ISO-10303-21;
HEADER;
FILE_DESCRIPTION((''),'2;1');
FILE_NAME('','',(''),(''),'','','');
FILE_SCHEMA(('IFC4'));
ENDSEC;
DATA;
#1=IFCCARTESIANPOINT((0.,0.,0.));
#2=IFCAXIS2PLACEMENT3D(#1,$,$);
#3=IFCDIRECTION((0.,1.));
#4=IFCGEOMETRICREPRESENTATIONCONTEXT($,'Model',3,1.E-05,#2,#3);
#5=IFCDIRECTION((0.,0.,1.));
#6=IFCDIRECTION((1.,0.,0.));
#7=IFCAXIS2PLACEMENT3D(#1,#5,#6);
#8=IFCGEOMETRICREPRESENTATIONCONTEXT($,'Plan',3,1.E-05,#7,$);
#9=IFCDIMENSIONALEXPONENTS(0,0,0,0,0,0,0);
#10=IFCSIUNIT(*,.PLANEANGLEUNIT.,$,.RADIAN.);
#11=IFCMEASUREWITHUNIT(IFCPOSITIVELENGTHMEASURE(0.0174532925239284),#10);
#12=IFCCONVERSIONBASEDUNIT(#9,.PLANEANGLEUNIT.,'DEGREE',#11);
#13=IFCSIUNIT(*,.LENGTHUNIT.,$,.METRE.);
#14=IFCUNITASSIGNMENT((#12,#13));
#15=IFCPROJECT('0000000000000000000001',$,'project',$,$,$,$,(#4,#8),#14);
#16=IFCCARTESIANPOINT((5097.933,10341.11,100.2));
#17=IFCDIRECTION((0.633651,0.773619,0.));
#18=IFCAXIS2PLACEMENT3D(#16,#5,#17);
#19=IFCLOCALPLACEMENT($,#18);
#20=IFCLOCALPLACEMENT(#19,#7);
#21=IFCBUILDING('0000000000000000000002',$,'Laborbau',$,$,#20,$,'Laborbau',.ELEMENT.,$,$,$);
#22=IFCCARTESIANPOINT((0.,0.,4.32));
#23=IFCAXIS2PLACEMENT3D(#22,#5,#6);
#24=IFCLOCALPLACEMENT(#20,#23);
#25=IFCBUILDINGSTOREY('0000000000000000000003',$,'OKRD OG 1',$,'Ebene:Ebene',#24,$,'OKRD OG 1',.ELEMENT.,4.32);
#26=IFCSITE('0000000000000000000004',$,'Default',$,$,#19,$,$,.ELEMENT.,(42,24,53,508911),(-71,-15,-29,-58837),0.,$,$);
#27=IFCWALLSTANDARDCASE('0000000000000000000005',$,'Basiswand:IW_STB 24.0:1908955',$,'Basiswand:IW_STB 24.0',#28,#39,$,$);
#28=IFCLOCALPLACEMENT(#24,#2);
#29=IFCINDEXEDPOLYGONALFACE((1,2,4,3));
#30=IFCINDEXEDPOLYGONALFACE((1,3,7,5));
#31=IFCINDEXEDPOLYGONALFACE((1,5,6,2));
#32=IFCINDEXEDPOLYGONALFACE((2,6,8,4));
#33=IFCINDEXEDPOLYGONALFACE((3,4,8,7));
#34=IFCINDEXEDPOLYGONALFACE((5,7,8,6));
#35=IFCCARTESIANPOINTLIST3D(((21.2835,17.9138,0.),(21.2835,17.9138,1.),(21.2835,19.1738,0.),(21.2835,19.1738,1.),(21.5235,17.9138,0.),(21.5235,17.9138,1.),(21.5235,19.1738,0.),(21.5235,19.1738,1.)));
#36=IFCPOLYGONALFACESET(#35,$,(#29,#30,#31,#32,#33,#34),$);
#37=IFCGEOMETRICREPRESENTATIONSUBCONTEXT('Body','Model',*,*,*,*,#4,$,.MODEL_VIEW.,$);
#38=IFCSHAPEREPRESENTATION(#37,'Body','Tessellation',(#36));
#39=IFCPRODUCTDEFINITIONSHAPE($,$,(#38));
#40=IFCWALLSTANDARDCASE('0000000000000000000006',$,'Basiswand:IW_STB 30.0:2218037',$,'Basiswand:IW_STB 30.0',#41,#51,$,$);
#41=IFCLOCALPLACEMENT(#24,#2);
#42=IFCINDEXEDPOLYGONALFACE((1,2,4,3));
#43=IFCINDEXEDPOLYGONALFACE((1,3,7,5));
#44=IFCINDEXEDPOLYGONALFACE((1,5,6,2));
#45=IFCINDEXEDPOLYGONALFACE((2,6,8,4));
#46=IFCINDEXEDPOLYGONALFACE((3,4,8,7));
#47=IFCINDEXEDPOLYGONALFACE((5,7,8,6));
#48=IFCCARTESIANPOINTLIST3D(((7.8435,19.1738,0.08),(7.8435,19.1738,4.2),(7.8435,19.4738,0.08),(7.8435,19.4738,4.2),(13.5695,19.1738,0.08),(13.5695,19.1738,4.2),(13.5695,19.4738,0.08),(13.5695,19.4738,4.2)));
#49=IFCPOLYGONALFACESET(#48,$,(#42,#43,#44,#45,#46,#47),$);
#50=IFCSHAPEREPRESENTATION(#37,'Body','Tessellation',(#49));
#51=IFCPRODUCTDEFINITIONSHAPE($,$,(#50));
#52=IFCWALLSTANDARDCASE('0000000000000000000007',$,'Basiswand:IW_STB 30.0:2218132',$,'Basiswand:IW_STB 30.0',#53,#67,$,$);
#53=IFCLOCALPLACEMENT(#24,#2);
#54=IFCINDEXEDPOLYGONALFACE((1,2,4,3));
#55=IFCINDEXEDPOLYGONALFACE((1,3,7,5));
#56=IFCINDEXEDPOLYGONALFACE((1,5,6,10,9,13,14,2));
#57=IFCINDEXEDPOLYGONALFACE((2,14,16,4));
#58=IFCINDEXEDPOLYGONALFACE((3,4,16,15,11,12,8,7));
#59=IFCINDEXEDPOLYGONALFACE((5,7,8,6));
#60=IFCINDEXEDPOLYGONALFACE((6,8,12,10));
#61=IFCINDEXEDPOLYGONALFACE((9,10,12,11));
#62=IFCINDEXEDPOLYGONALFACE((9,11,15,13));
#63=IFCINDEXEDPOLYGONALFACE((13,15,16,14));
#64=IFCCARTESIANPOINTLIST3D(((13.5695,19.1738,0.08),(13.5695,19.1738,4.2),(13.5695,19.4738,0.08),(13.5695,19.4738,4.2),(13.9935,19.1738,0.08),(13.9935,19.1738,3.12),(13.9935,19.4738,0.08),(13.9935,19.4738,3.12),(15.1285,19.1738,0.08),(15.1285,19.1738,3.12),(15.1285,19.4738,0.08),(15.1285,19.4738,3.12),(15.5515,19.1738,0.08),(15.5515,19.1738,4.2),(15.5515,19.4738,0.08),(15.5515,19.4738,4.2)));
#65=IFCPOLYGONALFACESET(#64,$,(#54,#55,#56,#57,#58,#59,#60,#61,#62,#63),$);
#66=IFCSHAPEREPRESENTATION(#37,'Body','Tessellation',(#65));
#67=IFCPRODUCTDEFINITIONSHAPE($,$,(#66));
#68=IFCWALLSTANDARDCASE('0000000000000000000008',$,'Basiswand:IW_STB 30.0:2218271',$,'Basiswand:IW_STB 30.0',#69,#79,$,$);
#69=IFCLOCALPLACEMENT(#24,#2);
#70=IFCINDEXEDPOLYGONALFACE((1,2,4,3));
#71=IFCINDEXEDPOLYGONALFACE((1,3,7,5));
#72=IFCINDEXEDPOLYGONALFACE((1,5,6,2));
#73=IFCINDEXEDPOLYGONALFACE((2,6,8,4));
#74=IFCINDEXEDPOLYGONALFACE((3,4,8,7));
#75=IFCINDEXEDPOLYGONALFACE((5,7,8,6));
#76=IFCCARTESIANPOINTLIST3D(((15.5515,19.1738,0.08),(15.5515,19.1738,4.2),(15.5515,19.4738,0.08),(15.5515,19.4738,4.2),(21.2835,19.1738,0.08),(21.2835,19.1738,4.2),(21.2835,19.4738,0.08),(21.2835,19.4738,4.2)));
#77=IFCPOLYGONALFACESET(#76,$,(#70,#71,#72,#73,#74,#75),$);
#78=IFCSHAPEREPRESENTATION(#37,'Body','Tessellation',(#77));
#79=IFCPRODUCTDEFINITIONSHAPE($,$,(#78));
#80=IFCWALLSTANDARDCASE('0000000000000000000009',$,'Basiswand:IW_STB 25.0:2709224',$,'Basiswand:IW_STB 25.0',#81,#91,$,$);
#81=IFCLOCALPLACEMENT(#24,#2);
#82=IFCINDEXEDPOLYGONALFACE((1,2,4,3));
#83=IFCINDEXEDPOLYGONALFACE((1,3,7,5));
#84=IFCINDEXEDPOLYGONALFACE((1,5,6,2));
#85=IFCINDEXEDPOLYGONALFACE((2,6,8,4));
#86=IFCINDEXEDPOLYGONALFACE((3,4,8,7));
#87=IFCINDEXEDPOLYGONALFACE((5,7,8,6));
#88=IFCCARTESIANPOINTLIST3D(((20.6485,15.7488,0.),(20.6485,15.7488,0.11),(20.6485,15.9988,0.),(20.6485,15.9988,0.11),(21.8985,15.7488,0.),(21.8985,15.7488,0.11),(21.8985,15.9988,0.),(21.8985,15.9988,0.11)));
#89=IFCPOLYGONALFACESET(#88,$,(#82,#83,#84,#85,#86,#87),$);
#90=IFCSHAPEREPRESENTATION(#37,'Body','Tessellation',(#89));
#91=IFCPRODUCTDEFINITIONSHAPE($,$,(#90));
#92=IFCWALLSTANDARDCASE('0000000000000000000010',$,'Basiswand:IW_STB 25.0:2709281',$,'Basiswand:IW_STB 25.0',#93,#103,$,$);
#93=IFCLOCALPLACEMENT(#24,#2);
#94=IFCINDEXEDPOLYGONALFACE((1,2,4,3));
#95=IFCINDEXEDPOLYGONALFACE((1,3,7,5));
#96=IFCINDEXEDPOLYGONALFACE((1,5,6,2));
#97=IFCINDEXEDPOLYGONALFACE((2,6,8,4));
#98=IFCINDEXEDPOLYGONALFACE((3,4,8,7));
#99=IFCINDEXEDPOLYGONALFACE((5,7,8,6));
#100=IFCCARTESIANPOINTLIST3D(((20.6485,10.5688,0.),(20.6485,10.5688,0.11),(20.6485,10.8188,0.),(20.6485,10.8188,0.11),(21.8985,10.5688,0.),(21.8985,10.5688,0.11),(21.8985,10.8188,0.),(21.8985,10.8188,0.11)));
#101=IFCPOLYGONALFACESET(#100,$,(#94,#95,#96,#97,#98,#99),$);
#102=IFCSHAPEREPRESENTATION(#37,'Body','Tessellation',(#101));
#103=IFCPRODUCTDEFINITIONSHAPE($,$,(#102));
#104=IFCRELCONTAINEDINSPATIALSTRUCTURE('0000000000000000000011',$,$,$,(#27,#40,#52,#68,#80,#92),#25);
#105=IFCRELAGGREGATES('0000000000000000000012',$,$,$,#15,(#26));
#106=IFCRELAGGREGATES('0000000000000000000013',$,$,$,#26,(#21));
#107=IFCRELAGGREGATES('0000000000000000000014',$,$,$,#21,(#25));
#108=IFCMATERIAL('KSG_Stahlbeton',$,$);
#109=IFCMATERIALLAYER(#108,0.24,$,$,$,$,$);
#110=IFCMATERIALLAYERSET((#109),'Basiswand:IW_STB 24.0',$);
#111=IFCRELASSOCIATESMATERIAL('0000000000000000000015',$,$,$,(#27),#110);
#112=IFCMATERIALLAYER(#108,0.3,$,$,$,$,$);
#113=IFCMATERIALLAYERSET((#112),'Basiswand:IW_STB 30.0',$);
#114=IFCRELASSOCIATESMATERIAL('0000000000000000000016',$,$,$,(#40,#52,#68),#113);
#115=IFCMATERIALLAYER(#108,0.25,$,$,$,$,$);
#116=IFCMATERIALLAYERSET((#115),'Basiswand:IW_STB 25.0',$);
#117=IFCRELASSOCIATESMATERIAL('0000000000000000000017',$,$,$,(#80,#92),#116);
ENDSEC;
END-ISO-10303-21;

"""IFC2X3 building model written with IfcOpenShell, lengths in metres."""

from ifc_helpers import new_model, entity, si_unit, converted_unit, direction, frame, frame_2d, origin, origin_with_axes, place, context, subcontext, project, spatial, rectangle, extrude, material, layer, layer_set, layer_usage, element, save


model = new_model("IFC2X3")

# Units and contexts
model_context = context("Model", 3, precision=1e-05, world=origin(), true_north=direction((0.0, 1.0)))
plan_context = context("Plan", 3, precision=1e-05, world=origin_with_axes())
body_context = subcontext(model_context, "Body", "Model", "MODEL_VIEW")
ifc_project = project(units=[converted_unit("PLANEANGLEUNIT", "DEGREE", entity("IfcPositiveLengthMeasure", 0.0174532925239284), si_unit("PLANEANGLEUNIT", "RADIAN"), dimensions=[0, 0, 0, 0, 0, 0, 0]), si_unit("LENGTHUNIT", "METRE")], contexts=[model_context, plan_context])

# Site, building, storey
site_placement = place(None, frame((5097.933, 10341.11, 100.2), z_axis=(0.0, 0.0, 1.0), x_axis=(0.633651, 0.773619, 0.0)))
site = spatial("IfcSite", under=ifc_project, at=site_placement, Name="Default", CompositionType="ELEMENT", RefLatitude=(42, 24, 53, 508911), RefLongitude=(-71, -15, -29, -58837), RefElevation=0.0)
building_placement = place(site_placement, origin_with_axes())
building = spatial("IfcBuilding", under=site, at=building_placement, Name="Laborbau", LongName="Laborbau", CompositionType="ELEMENT")
storey_placement = place(building_placement, frame((0.0, 0.0, 4.32), z_axis=(0.0, 0.0, 1.0), x_axis=(1.0, 0.0, 0.0)))
storey = spatial("IfcBuildingStorey", under=building, at=storey_placement, Name="OKRD OG 1", ObjectType="Ebene:Ebene", LongName="OKRD OG 1", CompositionType="ELEMENT", Elevation=4.32)

# Shared definitions
ifc_material_1 = material(Name="KSG_Stahlbeton")
ifc_layer_1 = layer(ifc_material_1, 0.25)
ifc_layer_set_1 = layer_set([ifc_layer_1], Name="Basiswand:IW_STB 25.0")

# Walls
ifc_layer_2 = layer(ifc_material_1, 0.24)
ifc_layer_set_2 = layer_set([ifc_layer_2], Name="Basiswand:IW_STB 24.0")
ifc_layer_usage_1 = layer_usage(ifc_layer_set_2, "AXIS2", "NEGATIVE", 0.12)
wall_1_placement = place(storey_placement, frame((21.4035, 17.9138, 0.0), z_axis=(0.0, 0.0, 1.0), x_axis=(0.0, 1.0, 0.0)))
element("IfcWallStandardCase", 1, at=wall_1_placement, inside=storey, material=ifc_layer_usage_1, Name="Basiswand:IW_STB 24.0:1908955", ObjectType="Basiswand:IW_STB 24.0", context=body_context, shape_type="SweptSolid", body=[
    extrude(rectangle(XDim=1.26, YDim=0.24, at=frame_2d((0.63, 0.0), x_axis=(-1.0, 0.0))), origin(), (0.0, 0.0, 1.0), 1.0),
])
ifc_layer_3 = layer(ifc_material_1, 0.3)
ifc_layer_set_3 = layer_set([ifc_layer_3], Name="Basiswand:IW_STB 30.0")
ifc_layer_usage_2 = layer_usage(ifc_layer_set_3, "AXIS2", "POSITIVE", -0.15)
wall_2_placement = place(storey_placement, frame((13.5695, 19.3238, 0.08), z_axis=(0.0, 0.0, 1.0), x_axis=(-1.0, 0.0, 0.0)))
element("IfcWallStandardCase", 2, at=wall_2_placement, inside=storey, material=ifc_layer_usage_2, Name="Basiswand:IW_STB 30.0:2218037", ObjectType="Basiswand:IW_STB 30.0", context=body_context, shape_type="SweptSolid", body=[
    extrude(rectangle(XDim=5.726, YDim=0.3, at=frame_2d((2.863, 0.0), x_axis=(-1.0, 0.0))), origin(), (0.0, 0.0, 1.0), 4.12),
])

# Wall, openings
ifc_layer_usage_3 = layer_usage(ifc_layer_set_3, "AXIS2", "POSITIVE", -0.15)
wall_3_placement = place(storey_placement, frame((15.5515, 19.3238, 0.08), z_axis=(0.0, 0.0, 1.0), x_axis=(-1.0, 0.0, 0.0)))
wall_3 = element("IfcWallStandardCase", 3, at=wall_3_placement, inside=storey, material=ifc_layer_usage_3, Name="Basiswand:IW_STB 30.0:2218132", ObjectType="Basiswand:IW_STB 30.0", context=body_context, shape_type="SweptSolid", body=[
    extrude(rectangle(XDim=1.982, YDim=0.3, at=frame_2d((0.991, 0.0), x_axis=(-1.0, 0.0))), origin(), (0.0, 0.0, 1.0), 4.12),
])
opening_1_placement = place(wall_3_placement, frame((0.423, -0.15, 0.0), z_axis=(0.0, 0.0, 1.0), x_axis=(1.0, 0.0, 0.0)))
element("IfcOpeningElement", 4, at=opening_1_placement, cuts=wall_3, ObjectType="Opening", context=body_context, shape_type="SweptSolid", body=[
    extrude(rectangle(XDim=3.04, YDim=1.135, at=frame_2d((1.52, 0.5675), x_axis=(1.0, 0.0))), frame((0.0, 0.0, 0.0), z_axis=(0.0, 1.0, 0.0), x_axis=(0.0, 0.0, 1.0)), (0.0, 0.0, 1.0), 0.3),
])
opening_2_placement = place(wall_3_placement, frame((15.5515, 19.3238, -0.08), z_axis=(0.0, 0.0, 1.0), x_axis=(-1.0, 0.0, 0.0)))
element("IfcOpeningElement", 5, at=opening_2_placement, cuts=wall_3, ObjectType="Opening", context=body_context, shape_type="SweptSolid", body=[
    extrude(rectangle(XDim=3.04, YDim=1.135, at=frame_2d((0.0, 0.0), x_axis=(0.0, 1.0))), frame((14.561, 20.6978, 1.6), z_axis=(0.0, -1.0, 0.0), x_axis=(1.0, 0.0, 0.0)), (0.0, 0.0, 1.0), 3.048),
])

# Walls
ifc_layer_usage_4 = layer_usage(ifc_layer_set_3, "AXIS2", "POSITIVE", -0.15)
wall_4_placement = place(storey_placement, frame((21.2835, 19.3238, 0.08), z_axis=(0.0, 0.0, 1.0), x_axis=(-1.0, 0.0, 0.0)))
element("IfcWallStandardCase", 6, at=wall_4_placement, inside=storey, material=ifc_layer_usage_4, Name="Basiswand:IW_STB 30.0:2218271", ObjectType="Basiswand:IW_STB 30.0", context=body_context, shape_type="SweptSolid", body=[
    extrude(rectangle(XDim=5.732, YDim=0.3, at=frame_2d((2.866, 0.0), x_axis=(-1.0, 0.0))), origin(), (0.0, 0.0, 1.0), 4.12),
])
ifc_layer_usage_5 = layer_usage(ifc_layer_set_1, "AXIS2", "NEGATIVE", 0.125)
wall_5_placement = place(storey_placement, frame((20.6485, 15.8738, 0.0), z_axis=(0.0, 0.0, 1.0), x_axis=(1.0, 0.0, 0.0)))
element("IfcWallStandardCase", 7, at=wall_5_placement, inside=storey, material=ifc_layer_usage_5, Name="Basiswand:IW_STB 25.0:2709224", ObjectType="Basiswand:IW_STB 25.0", context=body_context, shape_type="SweptSolid", body=[
    extrude(rectangle(XDim=1.25, YDim=0.25, at=frame_2d((0.625, 0.0), x_axis=(-1.0, 0.0))), origin(), (0.0, 0.0, 1.0), 0.11),
])
ifc_layer_usage_6 = layer_usage(ifc_layer_set_1, "AXIS2", "NEGATIVE", 0.125)
wall_6_placement = place(storey_placement, frame((20.6485, 10.6938, 0.0), z_axis=(0.0, 0.0, 1.0), x_axis=(1.0, 0.0, 0.0)))
element("IfcWallStandardCase", 8, at=wall_6_placement, inside=storey, material=ifc_layer_usage_6, Name="Basiswand:IW_STB 25.0:2709281", ObjectType="Basiswand:IW_STB 25.0", context=body_context, shape_type="SweptSolid", body=[
    extrude(rectangle(XDim=1.25, YDim=0.25, at=frame_2d((0.625, 0.0), x_axis=(-1.0, 0.0))), origin(), (0.0, 0.0, 1.0), 0.11),
])

save(model, "model.ifc")
